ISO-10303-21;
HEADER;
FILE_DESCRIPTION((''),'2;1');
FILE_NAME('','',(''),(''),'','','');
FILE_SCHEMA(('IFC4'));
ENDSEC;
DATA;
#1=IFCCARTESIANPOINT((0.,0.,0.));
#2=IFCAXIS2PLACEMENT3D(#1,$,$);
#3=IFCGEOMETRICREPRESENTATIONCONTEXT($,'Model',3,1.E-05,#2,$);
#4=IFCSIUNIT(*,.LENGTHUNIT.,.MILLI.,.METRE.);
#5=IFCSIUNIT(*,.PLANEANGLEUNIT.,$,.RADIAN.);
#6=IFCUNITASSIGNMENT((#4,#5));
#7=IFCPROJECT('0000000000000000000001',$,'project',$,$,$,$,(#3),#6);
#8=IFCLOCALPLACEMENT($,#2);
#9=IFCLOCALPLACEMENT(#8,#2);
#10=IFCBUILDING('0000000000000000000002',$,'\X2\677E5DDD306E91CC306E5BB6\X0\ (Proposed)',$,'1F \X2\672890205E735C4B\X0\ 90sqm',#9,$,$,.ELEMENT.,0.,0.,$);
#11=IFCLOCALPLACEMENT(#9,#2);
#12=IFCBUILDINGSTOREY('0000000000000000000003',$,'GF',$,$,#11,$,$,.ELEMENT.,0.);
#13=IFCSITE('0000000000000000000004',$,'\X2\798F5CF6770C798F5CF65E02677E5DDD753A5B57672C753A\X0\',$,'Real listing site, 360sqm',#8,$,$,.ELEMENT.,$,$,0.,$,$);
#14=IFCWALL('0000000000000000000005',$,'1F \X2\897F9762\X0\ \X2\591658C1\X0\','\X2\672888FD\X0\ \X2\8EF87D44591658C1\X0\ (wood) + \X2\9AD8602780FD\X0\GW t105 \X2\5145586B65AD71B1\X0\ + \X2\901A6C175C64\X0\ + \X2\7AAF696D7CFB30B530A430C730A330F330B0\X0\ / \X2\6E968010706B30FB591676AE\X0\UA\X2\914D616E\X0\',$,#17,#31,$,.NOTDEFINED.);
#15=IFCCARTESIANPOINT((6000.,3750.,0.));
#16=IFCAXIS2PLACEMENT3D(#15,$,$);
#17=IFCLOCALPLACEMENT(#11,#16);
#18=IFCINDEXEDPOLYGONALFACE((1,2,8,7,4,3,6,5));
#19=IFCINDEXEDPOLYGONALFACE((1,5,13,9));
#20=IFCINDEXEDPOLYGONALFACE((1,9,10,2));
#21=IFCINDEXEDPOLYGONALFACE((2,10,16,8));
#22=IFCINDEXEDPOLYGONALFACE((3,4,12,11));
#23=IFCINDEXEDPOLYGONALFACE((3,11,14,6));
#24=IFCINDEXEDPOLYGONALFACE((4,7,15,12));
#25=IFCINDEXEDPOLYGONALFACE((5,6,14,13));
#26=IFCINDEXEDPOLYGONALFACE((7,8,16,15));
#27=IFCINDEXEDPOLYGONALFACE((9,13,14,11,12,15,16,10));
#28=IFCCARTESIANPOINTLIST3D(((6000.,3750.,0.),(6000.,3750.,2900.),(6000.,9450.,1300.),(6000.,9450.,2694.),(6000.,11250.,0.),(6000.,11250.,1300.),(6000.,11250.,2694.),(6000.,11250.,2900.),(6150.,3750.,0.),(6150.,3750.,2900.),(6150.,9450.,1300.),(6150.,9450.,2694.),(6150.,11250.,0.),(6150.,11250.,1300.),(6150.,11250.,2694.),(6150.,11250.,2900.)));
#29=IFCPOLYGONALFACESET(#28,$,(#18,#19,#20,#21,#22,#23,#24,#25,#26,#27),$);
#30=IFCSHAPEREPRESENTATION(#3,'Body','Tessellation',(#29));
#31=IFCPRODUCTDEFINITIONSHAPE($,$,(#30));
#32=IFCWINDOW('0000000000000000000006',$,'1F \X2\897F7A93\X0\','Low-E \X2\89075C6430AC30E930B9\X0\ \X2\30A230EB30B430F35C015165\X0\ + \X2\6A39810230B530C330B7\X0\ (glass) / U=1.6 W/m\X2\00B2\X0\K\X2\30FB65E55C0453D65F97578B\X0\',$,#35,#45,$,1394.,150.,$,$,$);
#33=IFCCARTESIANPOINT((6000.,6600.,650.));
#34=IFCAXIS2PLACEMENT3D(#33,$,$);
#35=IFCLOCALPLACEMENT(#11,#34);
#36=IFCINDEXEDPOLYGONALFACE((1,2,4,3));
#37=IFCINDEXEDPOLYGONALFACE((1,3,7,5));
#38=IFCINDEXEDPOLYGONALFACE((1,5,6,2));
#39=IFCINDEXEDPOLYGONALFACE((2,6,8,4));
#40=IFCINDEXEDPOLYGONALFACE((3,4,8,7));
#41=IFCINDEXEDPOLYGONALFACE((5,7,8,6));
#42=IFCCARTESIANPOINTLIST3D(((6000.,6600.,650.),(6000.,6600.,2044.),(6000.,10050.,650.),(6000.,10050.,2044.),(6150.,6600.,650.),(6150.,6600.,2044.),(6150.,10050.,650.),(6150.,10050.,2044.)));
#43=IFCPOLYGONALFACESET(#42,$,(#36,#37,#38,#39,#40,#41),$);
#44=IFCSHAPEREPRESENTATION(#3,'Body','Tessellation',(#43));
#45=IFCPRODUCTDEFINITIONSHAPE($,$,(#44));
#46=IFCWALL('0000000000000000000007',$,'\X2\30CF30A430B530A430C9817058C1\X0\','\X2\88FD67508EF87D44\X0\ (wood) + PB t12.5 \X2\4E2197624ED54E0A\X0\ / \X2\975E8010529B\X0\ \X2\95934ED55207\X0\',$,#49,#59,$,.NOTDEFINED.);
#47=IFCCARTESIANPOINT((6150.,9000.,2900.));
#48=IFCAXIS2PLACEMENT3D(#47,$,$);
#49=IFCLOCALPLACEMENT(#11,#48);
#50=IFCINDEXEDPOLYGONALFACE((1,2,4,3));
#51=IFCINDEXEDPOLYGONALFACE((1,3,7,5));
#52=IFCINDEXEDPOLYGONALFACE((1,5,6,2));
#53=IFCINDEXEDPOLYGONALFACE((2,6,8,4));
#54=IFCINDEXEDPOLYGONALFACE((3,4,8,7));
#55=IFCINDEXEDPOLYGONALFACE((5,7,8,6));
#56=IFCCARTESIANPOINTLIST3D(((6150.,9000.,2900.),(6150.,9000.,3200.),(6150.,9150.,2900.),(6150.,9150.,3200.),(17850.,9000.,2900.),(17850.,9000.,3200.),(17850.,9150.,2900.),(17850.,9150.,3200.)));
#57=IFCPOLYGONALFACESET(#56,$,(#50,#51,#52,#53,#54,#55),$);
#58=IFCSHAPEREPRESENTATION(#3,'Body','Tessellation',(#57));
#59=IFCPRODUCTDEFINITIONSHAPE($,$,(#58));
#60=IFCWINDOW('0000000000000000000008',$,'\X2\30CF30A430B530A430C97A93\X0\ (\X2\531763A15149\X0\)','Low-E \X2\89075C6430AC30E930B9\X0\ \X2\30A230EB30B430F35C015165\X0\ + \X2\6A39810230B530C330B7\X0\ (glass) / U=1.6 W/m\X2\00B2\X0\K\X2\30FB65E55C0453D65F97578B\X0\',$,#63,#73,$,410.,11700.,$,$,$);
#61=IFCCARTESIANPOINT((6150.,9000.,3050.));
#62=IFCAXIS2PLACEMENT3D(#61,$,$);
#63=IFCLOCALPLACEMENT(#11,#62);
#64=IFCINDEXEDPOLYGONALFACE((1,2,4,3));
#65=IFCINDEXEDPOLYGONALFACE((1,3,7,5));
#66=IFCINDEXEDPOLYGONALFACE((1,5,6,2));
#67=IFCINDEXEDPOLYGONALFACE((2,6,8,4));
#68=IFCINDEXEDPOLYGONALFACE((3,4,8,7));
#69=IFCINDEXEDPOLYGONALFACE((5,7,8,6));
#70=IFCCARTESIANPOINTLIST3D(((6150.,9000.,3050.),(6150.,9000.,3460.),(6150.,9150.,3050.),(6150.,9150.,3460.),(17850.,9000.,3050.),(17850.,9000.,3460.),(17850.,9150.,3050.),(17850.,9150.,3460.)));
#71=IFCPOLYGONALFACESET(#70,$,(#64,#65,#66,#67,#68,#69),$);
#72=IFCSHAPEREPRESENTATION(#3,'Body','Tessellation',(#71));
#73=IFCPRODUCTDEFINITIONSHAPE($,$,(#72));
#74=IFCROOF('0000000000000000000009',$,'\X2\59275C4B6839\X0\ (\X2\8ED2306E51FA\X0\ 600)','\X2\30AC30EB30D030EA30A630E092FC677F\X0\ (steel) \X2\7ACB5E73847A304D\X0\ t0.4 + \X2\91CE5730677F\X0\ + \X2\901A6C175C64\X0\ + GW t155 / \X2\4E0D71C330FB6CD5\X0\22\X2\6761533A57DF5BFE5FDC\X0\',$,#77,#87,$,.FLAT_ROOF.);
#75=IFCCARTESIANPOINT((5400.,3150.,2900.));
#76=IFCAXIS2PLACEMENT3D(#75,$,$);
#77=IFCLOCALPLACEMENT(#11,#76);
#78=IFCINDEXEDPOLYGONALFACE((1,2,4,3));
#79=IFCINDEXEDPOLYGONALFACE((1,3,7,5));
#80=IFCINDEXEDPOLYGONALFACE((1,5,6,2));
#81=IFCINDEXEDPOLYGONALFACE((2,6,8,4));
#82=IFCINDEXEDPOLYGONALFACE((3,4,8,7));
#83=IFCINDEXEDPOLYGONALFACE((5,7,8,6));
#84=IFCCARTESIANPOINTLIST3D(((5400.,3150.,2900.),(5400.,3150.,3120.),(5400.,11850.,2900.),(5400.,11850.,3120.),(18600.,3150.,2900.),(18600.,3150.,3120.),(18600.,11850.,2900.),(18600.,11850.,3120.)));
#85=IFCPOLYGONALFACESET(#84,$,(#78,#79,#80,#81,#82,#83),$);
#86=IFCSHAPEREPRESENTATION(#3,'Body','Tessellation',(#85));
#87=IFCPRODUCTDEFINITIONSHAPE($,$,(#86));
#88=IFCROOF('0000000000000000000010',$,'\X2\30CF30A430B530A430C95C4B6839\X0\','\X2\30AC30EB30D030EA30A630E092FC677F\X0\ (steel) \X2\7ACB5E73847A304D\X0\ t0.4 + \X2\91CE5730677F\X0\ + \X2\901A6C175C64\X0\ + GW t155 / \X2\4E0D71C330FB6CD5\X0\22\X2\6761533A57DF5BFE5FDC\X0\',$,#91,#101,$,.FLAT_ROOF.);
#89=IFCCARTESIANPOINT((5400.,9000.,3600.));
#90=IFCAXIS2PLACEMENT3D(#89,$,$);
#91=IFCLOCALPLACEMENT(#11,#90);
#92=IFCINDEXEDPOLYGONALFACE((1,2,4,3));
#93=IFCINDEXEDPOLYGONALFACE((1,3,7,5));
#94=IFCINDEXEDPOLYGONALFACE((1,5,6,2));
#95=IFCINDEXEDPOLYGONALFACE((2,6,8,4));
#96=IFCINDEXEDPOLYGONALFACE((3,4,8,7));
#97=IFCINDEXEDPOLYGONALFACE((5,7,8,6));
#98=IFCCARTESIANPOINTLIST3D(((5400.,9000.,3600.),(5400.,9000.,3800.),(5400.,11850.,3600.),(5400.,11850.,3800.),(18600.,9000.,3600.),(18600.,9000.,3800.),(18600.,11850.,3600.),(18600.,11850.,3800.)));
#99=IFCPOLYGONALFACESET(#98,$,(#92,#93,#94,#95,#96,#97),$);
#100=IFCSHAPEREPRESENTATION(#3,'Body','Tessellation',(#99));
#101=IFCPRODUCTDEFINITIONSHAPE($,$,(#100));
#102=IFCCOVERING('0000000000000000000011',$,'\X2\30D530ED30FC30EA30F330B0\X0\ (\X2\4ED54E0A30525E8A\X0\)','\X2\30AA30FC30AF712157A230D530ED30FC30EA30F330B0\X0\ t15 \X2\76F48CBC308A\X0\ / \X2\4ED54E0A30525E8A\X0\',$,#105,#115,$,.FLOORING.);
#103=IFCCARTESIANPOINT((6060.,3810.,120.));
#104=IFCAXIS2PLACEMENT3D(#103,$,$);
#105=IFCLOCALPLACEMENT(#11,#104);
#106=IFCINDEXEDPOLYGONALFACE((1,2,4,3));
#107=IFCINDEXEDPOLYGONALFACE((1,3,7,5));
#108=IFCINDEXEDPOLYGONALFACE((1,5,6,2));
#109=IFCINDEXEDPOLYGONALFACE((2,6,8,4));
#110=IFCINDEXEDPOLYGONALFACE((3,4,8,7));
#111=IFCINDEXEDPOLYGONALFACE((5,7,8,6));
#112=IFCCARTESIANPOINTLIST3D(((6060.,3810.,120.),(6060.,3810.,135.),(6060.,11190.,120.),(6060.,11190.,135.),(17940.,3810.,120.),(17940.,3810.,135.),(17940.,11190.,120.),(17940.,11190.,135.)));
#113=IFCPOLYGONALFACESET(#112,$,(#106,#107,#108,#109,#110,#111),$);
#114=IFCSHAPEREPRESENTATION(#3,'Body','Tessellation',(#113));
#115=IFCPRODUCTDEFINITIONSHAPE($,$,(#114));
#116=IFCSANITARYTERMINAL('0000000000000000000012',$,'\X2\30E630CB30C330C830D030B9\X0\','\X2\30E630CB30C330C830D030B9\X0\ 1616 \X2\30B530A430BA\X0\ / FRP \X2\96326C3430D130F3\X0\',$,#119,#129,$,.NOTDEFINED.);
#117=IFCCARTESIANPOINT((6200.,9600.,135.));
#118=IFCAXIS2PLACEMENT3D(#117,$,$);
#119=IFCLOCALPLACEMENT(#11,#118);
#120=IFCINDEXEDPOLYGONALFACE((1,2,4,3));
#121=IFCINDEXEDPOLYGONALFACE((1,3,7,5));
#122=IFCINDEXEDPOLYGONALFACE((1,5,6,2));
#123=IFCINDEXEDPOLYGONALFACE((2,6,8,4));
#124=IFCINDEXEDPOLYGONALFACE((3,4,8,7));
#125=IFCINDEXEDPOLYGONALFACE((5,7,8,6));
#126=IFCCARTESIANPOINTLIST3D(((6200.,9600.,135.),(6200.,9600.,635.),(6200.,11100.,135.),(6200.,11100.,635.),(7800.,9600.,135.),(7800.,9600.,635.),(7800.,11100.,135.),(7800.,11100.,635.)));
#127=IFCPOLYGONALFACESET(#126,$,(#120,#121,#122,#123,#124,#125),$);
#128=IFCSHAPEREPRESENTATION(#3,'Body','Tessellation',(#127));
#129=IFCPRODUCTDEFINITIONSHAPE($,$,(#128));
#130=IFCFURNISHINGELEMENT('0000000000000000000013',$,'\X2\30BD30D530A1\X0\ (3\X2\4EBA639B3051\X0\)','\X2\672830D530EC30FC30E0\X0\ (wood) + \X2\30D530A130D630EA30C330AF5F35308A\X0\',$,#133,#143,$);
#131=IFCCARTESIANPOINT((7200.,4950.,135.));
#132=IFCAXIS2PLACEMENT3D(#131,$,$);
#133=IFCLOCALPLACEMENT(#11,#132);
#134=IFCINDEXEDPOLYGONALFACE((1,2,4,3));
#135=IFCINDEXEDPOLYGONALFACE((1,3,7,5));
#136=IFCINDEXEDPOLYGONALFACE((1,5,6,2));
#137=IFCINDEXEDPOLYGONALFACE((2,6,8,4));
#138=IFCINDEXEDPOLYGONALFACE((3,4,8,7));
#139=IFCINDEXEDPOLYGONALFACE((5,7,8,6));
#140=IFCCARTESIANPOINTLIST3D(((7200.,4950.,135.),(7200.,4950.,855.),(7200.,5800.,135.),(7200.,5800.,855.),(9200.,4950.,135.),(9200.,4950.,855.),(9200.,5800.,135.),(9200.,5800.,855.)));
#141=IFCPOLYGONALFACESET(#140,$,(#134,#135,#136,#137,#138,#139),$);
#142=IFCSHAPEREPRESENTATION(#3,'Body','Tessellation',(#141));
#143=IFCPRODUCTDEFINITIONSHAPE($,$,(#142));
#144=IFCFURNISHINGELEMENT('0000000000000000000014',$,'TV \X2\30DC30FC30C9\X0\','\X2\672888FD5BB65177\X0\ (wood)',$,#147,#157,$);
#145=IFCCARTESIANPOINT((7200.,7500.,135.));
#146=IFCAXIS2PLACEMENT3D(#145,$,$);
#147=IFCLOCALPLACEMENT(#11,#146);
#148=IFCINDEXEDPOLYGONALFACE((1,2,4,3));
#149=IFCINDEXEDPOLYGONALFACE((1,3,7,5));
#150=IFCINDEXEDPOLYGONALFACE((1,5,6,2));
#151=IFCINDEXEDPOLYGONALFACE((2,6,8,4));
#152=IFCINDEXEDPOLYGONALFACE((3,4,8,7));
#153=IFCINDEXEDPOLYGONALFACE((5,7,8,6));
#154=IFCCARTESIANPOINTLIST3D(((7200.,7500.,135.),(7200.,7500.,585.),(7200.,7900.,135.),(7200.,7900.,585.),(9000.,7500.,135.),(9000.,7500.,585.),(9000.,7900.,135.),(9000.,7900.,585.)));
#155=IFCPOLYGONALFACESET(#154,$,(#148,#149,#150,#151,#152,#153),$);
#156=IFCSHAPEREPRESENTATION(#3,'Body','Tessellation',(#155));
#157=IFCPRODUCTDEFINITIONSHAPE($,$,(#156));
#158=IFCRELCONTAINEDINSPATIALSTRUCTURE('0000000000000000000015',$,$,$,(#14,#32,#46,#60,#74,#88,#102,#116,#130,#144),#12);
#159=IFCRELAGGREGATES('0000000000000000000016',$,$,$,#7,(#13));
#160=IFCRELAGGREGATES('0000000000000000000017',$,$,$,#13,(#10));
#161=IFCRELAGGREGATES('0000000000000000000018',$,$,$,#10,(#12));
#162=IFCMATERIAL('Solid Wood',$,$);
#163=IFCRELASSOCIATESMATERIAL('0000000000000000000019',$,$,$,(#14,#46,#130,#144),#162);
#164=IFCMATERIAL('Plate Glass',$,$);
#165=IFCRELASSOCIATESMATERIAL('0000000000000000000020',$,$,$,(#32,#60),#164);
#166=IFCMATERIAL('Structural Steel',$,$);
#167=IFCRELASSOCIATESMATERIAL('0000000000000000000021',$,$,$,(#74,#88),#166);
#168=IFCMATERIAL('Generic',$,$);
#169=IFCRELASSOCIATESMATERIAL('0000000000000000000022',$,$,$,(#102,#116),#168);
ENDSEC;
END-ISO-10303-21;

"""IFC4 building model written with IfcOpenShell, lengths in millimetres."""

from ifc_helpers import new_model, si_unit, frame, frame_2d, origin, place, context, project, spatial, rectangle, extrude, material, element, fill, save


model = new_model("IFC4")

# Units and contexts
model_context = context("Model", 3, precision=1e-05, world=origin())
ifc_project = project(units=[si_unit("LENGTHUNIT", "METRE", prefix="MILLI"), si_unit("PLANEANGLEUNIT", "RADIAN")], contexts=[model_context])

# Site, building, storey
site_placement = place(None, origin())
site = spatial("IfcSite", under=ifc_project, at=site_placement, Name="福島県福島市松川町字本町", ObjectType="Real listing site, 360sqm", CompositionType="ELEMENT", RefElevation=0.0)
building_placement = place(site_placement, origin())
building = spatial("IfcBuilding", under=site, at=building_placement, Name="松川の里の家 (Proposed)", ObjectType="1F 木造平屋 90sqm", CompositionType="ELEMENT", ElevationOfRefHeight=0.0, ElevationOfTerrain=0.0)
storey_placement = place(building_placement, origin())
storey = spatial("IfcBuildingStorey", under=building, at=storey_placement, Name="GF", CompositionType="ELEMENT", Elevation=0.0)

# Shared definitions
ifc_material_1 = material(Name="Solid Wood")

# Shared definitions
ifc_material_2 = material(Name="Plate Glass")

# Wall, opening, window
wall_1_placement = place(storey_placement, frame((6000.0, 3750.0, 0.0)))
wall_1 = element("IfcWall", 1, at=wall_1_placement, inside=storey, material=ifc_material_1, Name="1F 西面 外壁", Description="木製 軸組外壁 (wood) + 高性能GW t105 充填断熱 + 通気層 + 窯業系サイディング / 準耐火・外皮UA配慮", PredefinedType="NOTDEFINED", context=model_context, shape_type="SweptSolid", body=[
    extrude(rectangle(XDim=150.0, YDim=7500.0, at=frame_2d((75.0, 3750.0))), frame((6000.0, 3750.0, 0.0)), (0.0, 0.0, 1.0), 2900.0),
])
opening_1_placement = place(storey_placement, frame((6000.0, 6600.0, 650.0)))
opening_1 = element("IfcOpeningElement", 2, at=opening_1_placement, cuts=wall_1, PredefinedType="NOTDEFINED", context=model_context, shape_type="SweptSolid", body=[
    extrude(rectangle(XDim=150.0, YDim=3450.0, at=frame_2d((75.0, 1725.0))), frame((6000.0, 6600.0, 650.0)), (0.0, 0.0, 1.0), 1394.0),
])
window_1_placement = place(storey_placement, frame((6000.0, 6600.0, 650.0)))
window_1 = element("IfcWindow", 3, at=window_1_placement, inside=storey, material=ifc_material_2, Name="1F 西窓", Description="Low-E 複層ガラス アルゴン封入 + 樹脂サッシ (glass) / U=1.6 W/m²K・日射取得型", OverallHeight=1394.0, OverallWidth=150.0, context=model_context, shape_type="SweptSolid", body=[
    extrude(rectangle(XDim=150.0, YDim=3450.0, at=frame_2d((75.0, 1725.0))), frame((6000.0, 6600.0, 650.0)), (0.0, 0.0, 1.0), 1394.0),
])
fill(opening_1, window_1)

# Wall, opening, window
wall_2_placement = place(storey_placement, frame((6150.0, 9000.0, 2900.0)))
wall_2 = element("IfcWall", 4, at=wall_2_placement, inside=storey, material=ifc_material_1, Name="ハイサイド腰壁", Description="製材軸組 (wood) + PB t12.5 両面仕上 / 非耐力 間仕切", PredefinedType="NOTDEFINED", context=model_context, shape_type="SweptSolid", body=[
    extrude(rectangle(XDim=11700.0, YDim=150.0, at=frame_2d((5850.0, 75.0))), frame((6150.0, 9000.0, 2900.0)), (0.0, 0.0, 1.0), 700.0),
])
opening_2_placement = place(storey_placement, frame((6150.0, 9000.0, 3050.0)))
opening_2 = element("IfcOpeningElement", 5, at=opening_2_placement, cuts=wall_2, PredefinedType="NOTDEFINED", context=model_context, shape_type="SweptSolid", body=[
    extrude(rectangle(XDim=11700.0, YDim=150.0, at=frame_2d((5850.0, 75.0))), frame((6150.0, 9000.0, 3050.0)), (0.0, 0.0, 1.0), 410.0),
])
window_2_placement = place(storey_placement, frame((6150.0, 9000.0, 3050.0)))
window_2 = element("IfcWindow", 6, at=window_2_placement, inside=storey, material=ifc_material_2, Name="ハイサイド窓 (北採光)", Description="Low-E 複層ガラス アルゴン封入 + 樹脂サッシ (glass) / U=1.6 W/m²K・日射取得型", OverallHeight=410.0, OverallWidth=11700.0, context=model_context, shape_type="SweptSolid", body=[
    extrude(rectangle(XDim=11700.0, YDim=150.0, at=frame_2d((5850.0, 75.0))), frame((6150.0, 9000.0, 3050.0)), (0.0, 0.0, 1.0), 410.0),
])
fill(opening_2, window_2)

# Roofs
ifc_material_3 = material(Name="Structural Steel")
roof_1_placement = place(storey_placement, frame((5400.0, 3150.0, 2900.0)))
element("IfcRoof", 7, at=roof_1_placement, inside=storey, material=ifc_material_3, Name="大屋根 (軒の出 600)", Description="ガルバリウム鋼板 (steel) 立平葺き t0.4 + 野地板 + 通気層 + GW t155 / 不燃・法22条区域対応", PredefinedType="FLAT_ROOF", context=model_context, shape_type="SweptSolid", body=[
    extrude(rectangle(XDim=13200.0, YDim=8700.0, at=frame_2d((6600.0, 4350.0))), frame((5400.0, 3150.0, 2900.0)), (0.0, 0.0, 1.0), 220.0),
])
roof_2_placement = place(storey_placement, frame((5400.0, 9000.0, 3600.0)))
element("IfcRoof", 8, at=roof_2_placement, inside=storey, material=ifc_material_3, Name="ハイサイド屋根", Description="ガルバリウム鋼板 (steel) 立平葺き t0.4 + 野地板 + 通気層 + GW t155 / 不燃・法22条区域対応", PredefinedType="FLAT_ROOF", context=model_context, shape_type="SweptSolid", body=[
    extrude(rectangle(XDim=13200.0, YDim=2850.0, at=frame_2d((6600.0, 1425.0))), frame((5400.0, 9000.0, 3600.0)), (0.0, 0.0, 1.0), 200.0),
])

# Covering
ifc_material_4 = material(Name="Generic")
covering_placement = place(storey_placement, frame((6060.0, 3810.0, 120.0)))
element("IfcCovering", 9, at=covering_placement, inside=storey, material=ifc_material_4, Name="フローリング (仕上げ床)", Description="オーク無垢フローリング t15 直貼り / 仕上げ床", PredefinedType="FLOORING", context=model_context, shape_type="SweptSolid", body=[
    extrude(rectangle(XDim=11880.0, YDim=7380.0, at=frame_2d((5940.0, 3690.0))), frame((6060.0, 3810.0, 120.0)), (0.0, 0.0, 1.0), 15.0),
])

# Sanitary terminal
sanitary_terminal_placement = place(storey_placement, frame((6200.0, 9600.0, 135.0)))
element("IfcSanitaryTerminal", 10, at=sanitary_terminal_placement, inside=storey, material=ifc_material_4, Name="ユニットバス", Description="ユニットバス 1616 サイズ / FRP 防水パン", PredefinedType="NOTDEFINED", context=model_context, shape_type="SweptSolid", body=[
    extrude(rectangle(XDim=1600.0, YDim=1500.0, at=frame_2d((800.0, 750.0))), frame((6200.0, 9600.0, 135.0)), (0.0, 0.0, 1.0), 500.0),
])

# Furnishing elements
furnishing_1_placement = place(storey_placement, frame((7200.0, 4950.0, 135.0)))
element("IfcFurnishingElement", 11, at=furnishing_1_placement, inside=storey, material=ifc_material_1, Name="ソファ (3人掛け)", Description="木フレーム (wood) + ファブリック張り", context=model_context, shape_type="SweptSolid", body=[
    extrude(rectangle(XDim=2000.0, YDim=850.0, at=frame_2d((1000.0, 425.0))), frame((7200.0, 4950.0, 135.0)), (0.0, 0.0, 1.0), 720.0),
])
furnishing_2_placement = place(storey_placement, frame((7200.0, 7500.0, 135.0)))
element("IfcFurnishingElement", 12, at=furnishing_2_placement, inside=storey, material=ifc_material_1, Name="TV ボード", Description="木製家具 (wood)", context=model_context, shape_type="SweptSolid", body=[
    extrude(rectangle(XDim=1800.0, YDim=400.0, at=frame_2d((900.0, 200.0))), frame((7200.0, 7500.0, 135.0)), (0.0, 0.0, 1.0), 450.0),
])

save(model, "model.ifc")
